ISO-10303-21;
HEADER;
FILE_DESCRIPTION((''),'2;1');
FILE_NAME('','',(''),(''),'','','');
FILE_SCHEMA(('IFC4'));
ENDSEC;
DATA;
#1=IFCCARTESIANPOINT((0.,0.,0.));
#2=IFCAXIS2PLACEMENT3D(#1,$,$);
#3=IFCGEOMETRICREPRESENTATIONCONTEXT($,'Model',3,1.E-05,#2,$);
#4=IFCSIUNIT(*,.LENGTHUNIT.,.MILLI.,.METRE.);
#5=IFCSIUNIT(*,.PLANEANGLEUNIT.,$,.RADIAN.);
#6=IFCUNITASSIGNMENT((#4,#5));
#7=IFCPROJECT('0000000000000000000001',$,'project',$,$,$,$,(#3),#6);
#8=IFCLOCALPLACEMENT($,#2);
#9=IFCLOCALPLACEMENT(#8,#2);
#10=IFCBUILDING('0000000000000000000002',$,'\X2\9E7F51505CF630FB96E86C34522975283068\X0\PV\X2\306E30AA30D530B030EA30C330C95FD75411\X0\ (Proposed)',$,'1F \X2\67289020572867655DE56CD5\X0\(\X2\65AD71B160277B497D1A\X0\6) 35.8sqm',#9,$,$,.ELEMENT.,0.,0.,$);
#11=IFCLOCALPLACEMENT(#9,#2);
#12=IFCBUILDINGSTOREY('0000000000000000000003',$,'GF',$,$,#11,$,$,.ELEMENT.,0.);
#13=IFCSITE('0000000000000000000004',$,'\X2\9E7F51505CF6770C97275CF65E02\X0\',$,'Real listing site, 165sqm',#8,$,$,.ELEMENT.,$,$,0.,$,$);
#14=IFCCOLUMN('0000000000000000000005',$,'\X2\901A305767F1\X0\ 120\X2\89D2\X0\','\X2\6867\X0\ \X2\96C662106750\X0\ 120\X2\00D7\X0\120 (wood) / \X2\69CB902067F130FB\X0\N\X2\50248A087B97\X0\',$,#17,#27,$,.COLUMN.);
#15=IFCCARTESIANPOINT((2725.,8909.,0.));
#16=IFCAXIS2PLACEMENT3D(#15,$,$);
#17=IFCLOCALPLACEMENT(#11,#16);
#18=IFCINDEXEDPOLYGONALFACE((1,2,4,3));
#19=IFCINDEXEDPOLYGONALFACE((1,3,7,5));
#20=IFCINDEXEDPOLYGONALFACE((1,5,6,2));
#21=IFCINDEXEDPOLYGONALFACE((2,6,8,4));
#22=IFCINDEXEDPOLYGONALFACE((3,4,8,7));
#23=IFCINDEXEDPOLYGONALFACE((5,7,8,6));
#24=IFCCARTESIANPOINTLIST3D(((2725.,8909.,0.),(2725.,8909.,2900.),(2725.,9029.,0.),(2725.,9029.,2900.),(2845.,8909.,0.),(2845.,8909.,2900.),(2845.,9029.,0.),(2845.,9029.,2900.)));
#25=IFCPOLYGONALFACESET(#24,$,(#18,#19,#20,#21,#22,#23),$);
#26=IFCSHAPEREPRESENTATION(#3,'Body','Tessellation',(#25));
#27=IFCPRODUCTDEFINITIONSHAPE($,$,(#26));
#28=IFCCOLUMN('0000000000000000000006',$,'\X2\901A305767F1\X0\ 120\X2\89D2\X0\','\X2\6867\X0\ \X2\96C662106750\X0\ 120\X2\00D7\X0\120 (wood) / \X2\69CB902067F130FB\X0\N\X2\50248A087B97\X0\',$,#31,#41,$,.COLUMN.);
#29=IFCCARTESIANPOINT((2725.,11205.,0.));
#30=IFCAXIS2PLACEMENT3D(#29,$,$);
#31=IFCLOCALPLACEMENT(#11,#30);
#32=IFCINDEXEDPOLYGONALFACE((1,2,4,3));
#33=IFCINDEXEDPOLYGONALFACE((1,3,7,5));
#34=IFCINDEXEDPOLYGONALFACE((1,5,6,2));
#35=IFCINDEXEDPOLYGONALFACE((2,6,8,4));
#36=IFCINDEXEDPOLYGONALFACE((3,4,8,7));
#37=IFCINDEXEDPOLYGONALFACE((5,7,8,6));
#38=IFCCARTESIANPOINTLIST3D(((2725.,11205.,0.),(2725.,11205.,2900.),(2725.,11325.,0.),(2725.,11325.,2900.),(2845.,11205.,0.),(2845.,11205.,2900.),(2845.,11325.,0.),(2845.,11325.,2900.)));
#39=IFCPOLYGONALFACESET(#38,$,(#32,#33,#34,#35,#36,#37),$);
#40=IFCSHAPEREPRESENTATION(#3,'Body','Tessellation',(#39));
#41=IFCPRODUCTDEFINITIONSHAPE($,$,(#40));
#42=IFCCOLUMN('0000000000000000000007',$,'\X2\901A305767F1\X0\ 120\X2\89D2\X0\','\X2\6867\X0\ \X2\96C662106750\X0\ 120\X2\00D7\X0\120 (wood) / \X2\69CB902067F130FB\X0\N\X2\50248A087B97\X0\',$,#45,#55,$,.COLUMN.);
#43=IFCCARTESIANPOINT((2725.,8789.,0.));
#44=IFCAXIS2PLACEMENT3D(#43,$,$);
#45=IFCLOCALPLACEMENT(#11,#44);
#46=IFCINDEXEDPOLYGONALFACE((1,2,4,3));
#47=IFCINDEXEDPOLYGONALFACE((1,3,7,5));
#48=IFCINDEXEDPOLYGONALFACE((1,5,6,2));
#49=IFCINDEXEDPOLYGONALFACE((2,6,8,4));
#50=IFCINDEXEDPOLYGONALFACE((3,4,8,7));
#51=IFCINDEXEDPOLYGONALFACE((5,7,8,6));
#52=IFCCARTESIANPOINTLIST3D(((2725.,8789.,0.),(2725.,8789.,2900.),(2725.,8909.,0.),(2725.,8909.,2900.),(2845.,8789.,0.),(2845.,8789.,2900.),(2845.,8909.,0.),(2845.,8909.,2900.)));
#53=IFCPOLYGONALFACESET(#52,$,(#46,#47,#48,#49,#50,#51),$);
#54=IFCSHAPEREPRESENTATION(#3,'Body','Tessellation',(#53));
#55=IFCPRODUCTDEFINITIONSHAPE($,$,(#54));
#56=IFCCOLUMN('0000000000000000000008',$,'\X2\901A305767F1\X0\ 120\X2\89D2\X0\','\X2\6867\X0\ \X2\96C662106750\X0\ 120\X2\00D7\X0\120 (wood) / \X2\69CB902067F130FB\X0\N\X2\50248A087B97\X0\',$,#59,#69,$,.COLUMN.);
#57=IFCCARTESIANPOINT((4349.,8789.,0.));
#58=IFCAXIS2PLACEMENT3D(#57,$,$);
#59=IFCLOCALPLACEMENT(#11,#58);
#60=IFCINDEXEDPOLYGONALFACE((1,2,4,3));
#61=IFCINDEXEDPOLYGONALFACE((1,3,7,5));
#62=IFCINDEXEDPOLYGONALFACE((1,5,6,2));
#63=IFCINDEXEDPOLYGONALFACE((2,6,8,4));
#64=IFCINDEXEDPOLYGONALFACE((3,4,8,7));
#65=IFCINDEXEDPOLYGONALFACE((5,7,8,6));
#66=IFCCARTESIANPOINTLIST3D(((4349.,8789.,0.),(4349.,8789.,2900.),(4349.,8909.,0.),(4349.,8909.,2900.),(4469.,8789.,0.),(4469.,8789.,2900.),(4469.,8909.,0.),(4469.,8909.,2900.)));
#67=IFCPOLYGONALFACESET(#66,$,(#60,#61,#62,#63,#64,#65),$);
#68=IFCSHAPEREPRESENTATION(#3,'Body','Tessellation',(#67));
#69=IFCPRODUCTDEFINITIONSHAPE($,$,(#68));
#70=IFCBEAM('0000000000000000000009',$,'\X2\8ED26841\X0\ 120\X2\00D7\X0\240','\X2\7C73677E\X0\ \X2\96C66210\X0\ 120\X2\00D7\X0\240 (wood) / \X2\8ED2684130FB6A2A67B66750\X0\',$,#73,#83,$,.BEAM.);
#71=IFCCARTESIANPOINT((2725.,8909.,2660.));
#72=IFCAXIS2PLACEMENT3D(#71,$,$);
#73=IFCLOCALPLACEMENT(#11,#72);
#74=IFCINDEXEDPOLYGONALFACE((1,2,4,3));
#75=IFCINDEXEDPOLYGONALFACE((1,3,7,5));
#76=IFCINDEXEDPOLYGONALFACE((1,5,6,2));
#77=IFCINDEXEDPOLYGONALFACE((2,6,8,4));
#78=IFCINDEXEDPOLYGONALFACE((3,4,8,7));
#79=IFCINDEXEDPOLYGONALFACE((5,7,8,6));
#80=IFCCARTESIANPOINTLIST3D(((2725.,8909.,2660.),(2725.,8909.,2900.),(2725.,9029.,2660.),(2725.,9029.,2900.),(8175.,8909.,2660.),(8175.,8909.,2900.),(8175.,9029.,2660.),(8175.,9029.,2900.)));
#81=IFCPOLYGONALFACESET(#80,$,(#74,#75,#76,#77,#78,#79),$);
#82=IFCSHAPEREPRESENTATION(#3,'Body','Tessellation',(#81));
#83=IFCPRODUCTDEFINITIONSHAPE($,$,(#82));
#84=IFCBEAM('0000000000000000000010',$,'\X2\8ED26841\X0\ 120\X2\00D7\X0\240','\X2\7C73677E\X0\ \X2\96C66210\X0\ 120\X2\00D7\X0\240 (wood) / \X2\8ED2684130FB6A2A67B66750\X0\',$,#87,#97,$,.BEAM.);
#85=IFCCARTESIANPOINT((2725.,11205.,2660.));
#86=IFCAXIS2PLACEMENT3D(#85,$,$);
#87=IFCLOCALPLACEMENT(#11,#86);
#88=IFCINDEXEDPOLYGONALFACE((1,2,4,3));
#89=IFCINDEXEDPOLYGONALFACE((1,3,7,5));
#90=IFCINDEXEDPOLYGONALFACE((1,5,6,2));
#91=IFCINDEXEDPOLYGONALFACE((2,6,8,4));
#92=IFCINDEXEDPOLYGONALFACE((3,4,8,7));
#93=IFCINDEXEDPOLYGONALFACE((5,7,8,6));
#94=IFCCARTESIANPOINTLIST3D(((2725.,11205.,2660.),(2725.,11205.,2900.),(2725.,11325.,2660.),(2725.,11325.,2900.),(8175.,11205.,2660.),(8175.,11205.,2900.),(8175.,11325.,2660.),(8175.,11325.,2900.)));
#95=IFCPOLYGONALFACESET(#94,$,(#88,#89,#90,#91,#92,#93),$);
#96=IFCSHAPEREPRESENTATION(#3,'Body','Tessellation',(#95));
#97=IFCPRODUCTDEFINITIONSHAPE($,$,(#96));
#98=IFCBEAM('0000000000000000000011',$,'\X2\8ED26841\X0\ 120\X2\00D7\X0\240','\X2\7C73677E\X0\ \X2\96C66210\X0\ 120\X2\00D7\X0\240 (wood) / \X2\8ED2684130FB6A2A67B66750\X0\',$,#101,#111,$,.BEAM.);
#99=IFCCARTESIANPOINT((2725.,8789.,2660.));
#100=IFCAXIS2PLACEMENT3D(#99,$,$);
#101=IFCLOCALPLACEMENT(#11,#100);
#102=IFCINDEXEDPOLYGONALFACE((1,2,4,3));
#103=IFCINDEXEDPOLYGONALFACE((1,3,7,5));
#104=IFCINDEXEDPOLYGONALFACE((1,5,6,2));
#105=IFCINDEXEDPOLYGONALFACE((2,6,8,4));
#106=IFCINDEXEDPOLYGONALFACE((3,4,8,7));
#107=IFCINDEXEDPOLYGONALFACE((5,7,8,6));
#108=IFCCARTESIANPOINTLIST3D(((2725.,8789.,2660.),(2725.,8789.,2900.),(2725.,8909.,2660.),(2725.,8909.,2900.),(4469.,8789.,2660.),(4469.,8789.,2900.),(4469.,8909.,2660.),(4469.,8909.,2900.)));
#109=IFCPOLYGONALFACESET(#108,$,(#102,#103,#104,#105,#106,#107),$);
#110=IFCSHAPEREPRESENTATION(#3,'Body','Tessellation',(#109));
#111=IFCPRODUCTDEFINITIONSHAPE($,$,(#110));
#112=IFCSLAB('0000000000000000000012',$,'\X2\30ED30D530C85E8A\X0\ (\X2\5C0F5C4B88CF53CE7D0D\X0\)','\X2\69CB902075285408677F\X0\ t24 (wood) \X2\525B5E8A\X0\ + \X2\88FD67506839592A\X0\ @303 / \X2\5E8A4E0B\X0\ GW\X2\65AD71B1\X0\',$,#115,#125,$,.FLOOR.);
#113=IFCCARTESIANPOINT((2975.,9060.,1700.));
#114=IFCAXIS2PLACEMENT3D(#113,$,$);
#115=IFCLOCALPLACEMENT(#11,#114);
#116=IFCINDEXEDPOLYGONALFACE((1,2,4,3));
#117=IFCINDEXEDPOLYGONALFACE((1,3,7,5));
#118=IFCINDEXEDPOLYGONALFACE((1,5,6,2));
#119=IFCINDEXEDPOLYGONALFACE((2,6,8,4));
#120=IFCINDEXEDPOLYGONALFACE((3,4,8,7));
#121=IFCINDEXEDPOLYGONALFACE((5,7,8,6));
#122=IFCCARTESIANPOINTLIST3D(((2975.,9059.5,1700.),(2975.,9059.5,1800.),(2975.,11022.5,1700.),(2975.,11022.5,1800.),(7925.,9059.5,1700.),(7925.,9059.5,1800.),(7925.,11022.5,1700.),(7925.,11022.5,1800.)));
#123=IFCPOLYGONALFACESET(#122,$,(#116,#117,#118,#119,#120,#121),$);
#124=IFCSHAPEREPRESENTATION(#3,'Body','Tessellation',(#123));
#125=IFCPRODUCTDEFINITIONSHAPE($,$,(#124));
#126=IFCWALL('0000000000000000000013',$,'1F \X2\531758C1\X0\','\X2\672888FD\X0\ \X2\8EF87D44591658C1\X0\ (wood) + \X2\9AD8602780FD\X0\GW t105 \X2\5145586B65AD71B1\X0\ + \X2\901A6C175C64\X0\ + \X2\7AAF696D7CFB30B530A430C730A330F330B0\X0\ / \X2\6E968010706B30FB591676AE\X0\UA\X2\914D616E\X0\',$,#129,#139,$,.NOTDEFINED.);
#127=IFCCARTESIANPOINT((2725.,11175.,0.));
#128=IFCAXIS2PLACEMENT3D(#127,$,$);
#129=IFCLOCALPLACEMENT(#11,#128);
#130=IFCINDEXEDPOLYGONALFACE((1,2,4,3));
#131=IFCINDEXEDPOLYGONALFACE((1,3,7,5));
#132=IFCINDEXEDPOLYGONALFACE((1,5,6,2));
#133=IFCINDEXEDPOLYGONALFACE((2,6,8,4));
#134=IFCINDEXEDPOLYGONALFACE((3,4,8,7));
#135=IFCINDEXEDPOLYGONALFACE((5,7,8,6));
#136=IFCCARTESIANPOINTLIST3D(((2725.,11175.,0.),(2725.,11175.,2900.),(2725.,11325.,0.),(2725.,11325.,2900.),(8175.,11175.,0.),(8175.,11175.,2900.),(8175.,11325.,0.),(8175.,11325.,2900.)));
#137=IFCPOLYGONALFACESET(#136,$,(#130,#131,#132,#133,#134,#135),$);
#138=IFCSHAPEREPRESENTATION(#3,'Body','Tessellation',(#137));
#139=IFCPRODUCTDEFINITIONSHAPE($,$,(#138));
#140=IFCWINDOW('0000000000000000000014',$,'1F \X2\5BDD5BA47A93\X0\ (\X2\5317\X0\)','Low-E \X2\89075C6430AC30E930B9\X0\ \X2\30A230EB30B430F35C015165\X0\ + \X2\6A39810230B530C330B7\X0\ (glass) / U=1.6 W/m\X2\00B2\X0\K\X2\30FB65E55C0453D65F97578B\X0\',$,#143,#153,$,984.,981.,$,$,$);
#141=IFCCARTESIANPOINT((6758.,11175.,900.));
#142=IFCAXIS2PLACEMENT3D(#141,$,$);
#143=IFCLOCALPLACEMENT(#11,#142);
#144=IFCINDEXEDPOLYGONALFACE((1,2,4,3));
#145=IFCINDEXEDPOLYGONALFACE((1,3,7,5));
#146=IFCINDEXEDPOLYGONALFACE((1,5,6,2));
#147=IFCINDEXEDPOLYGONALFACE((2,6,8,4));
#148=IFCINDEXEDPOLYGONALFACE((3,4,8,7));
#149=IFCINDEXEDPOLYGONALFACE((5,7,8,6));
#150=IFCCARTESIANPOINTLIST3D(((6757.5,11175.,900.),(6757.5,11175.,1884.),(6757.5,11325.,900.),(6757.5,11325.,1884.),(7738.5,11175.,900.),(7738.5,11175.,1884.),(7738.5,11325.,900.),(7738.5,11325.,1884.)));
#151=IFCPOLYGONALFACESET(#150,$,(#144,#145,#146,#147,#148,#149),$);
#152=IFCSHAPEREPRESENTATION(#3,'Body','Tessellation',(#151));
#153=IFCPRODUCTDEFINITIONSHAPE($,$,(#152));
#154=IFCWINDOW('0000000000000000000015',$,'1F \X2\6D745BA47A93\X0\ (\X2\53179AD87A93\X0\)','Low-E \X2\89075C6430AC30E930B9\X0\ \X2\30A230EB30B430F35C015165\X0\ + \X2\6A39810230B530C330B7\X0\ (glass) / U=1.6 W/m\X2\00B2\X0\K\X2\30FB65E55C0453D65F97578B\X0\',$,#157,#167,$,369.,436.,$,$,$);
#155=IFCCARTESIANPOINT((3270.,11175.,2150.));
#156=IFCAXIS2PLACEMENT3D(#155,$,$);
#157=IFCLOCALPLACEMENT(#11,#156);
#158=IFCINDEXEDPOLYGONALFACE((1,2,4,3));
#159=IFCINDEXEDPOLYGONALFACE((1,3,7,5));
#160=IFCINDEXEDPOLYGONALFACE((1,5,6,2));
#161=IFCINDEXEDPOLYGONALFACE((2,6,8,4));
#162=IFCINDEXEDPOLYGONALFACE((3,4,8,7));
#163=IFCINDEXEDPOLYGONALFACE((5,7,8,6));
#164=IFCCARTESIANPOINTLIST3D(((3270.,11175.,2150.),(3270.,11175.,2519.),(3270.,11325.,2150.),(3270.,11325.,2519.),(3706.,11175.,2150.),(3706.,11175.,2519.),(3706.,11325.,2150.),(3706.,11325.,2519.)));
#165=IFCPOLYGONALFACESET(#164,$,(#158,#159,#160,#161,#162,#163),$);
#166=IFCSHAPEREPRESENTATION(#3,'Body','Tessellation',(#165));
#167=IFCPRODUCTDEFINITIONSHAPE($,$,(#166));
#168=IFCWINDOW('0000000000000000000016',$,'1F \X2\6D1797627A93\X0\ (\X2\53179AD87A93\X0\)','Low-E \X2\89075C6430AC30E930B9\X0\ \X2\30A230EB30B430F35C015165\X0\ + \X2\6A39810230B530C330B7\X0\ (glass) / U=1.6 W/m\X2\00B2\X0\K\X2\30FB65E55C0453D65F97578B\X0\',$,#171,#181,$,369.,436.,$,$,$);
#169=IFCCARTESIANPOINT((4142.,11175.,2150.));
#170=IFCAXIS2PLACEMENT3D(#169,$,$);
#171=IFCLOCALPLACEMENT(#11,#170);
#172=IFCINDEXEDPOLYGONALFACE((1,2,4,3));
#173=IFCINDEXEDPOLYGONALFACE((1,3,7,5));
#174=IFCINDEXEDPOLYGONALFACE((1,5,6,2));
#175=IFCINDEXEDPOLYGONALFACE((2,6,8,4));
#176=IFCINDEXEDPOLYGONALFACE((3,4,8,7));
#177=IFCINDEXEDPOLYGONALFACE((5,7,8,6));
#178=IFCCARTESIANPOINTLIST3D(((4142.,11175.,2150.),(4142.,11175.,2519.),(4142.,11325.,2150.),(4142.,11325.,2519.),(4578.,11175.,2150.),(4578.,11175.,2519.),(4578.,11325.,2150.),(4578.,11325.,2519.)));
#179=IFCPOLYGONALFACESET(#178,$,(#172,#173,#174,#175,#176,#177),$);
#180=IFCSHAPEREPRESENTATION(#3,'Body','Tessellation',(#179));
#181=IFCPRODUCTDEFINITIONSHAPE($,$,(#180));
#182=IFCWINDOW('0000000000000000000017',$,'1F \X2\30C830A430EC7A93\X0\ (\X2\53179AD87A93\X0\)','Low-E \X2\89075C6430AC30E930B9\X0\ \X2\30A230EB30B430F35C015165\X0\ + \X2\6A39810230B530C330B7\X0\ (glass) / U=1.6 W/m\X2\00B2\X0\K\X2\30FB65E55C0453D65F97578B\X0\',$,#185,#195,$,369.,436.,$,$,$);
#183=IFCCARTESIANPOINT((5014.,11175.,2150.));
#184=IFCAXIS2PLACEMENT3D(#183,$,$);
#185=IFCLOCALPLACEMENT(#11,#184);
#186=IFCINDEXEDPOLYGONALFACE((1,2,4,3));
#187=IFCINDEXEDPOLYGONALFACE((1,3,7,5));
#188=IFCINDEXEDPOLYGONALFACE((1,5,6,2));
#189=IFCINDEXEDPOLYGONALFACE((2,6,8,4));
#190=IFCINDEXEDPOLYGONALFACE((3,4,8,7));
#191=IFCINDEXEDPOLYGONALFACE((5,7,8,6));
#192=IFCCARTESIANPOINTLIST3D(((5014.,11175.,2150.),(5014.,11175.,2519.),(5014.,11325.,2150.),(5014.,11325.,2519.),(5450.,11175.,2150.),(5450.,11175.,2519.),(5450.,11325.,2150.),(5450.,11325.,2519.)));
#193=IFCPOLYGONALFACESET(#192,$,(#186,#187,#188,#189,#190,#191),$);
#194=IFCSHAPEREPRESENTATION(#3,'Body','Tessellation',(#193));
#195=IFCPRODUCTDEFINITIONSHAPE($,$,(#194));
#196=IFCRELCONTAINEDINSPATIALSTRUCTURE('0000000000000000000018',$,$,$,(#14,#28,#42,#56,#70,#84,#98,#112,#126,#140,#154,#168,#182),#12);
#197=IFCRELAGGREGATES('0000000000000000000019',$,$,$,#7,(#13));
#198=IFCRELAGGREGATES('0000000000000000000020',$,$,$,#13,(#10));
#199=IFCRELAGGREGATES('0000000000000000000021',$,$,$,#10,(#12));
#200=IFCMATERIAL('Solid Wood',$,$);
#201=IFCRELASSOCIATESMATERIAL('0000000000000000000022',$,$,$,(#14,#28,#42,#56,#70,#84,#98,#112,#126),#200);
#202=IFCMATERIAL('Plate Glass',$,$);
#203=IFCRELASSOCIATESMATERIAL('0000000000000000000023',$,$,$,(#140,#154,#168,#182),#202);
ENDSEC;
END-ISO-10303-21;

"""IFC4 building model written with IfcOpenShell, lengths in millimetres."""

from ifc_helpers import new_model, si_unit, frame, frame_2d, origin, place, context, project, spatial, rectangle, extrude, material, element, fill, save


model = new_model("IFC4")

# Units and contexts
model_context = context("Model", 3, precision=1e-05, world=origin())
ifc_project = project(units=[si_unit("LENGTHUNIT", "METRE", prefix="MILLI"), si_unit("PLANEANGLEUNIT", "RADIAN")], contexts=[model_context])

# Site, building, storey
site_placement = place(None, origin())
site = spatial("IfcSite", under=ifc_project, at=site_placement, Name="鹿児島県霧島市", ObjectType="Real listing site, 165sqm", CompositionType="ELEMENT", RefElevation=0.0)
building_placement = place(site_placement, origin())
building = spatial("IfcBuilding", under=site, at=building_placement, Name="鹿児島・雨水利用とPVのオフグリッド志向 (Proposed)", ObjectType="1F 木造在来工法(断熱性等級6) 35.8sqm", CompositionType="ELEMENT", ElevationOfRefHeight=0.0, ElevationOfTerrain=0.0)
storey_placement = place(building_placement, origin())
storey = spatial("IfcBuildingStorey", under=building, at=storey_placement, Name="GF", CompositionType="ELEMENT", Elevation=0.0)

# Columns
ifc_material_1 = material(Name="Solid Wood")
column_1_placement = place(storey_placement, frame((2725.0, 8909.0, 0.0)))
element("IfcColumn", 1, at=column_1_placement, inside=storey, material=ifc_material_1, Name="通し柱 120角", Description="桧 集成材 120×120 (wood) / 構造柱・N値計算", PredefinedType="COLUMN", context=model_context, shape_type="SweptSolid", body=[
    extrude(rectangle(XDim=120.0, YDim=120.0, at=frame_2d((60.0, 60.0))), frame((2725.0, 8909.0, 0.0)), (0.0, 0.0, 1.0), 2900.0),
])
column_2_placement = place(storey_placement, frame((2725.0, 11205.0, 0.0)))
element("IfcColumn", 2, at=column_2_placement, inside=storey, material=ifc_material_1, Name="通し柱 120角", Description="桧 集成材 120×120 (wood) / 構造柱・N値計算", PredefinedType="COLUMN", context=model_context, shape_type="SweptSolid", body=[
    extrude(rectangle(XDim=120.0, YDim=120.0, at=frame_2d((60.0, 60.0))), frame((2725.0, 11205.0, 0.0)), (0.0, 0.0, 1.0), 2900.0),
])
column_3_placement = place(storey_placement, frame((2725.0, 8789.0, 0.0)))
element("IfcColumn", 3, at=column_3_placement, inside=storey, material=ifc_material_1, Name="通し柱 120角", Description="桧 集成材 120×120 (wood) / 構造柱・N値計算", PredefinedType="COLUMN", context=model_context, shape_type="SweptSolid", body=[
    extrude(rectangle(XDim=120.0, YDim=120.0, at=frame_2d((60.0, 60.0))), frame((2725.0, 8789.0, 0.0)), (0.0, 0.0, 1.0), 2900.0),
])
column_4_placement = place(storey_placement, frame((4349.0, 8789.0, 0.0)))
element("IfcColumn", 4, at=column_4_placement, inside=storey, material=ifc_material_1, Name="通し柱 120角", Description="桧 集成材 120×120 (wood) / 構造柱・N値計算", PredefinedType="COLUMN", context=model_context, shape_type="SweptSolid", body=[
    extrude(rectangle(XDim=120.0, YDim=120.0, at=frame_2d((60.0, 60.0))), frame((4349.0, 8789.0, 0.0)), (0.0, 0.0, 1.0), 2900.0),
])

# Beams
beam_1_placement = place(storey_placement, frame((2725.0, 8909.0, 2660.0)))
element("IfcBeam", 5, at=beam_1_placement, inside=storey, material=ifc_material_1, Name="軒桁 120×240", Description="米松 集成 120×240 (wood) / 軒桁・横架材", PredefinedType="BEAM", context=model_context, shape_type="SweptSolid", body=[
    extrude(rectangle(XDim=5450.0, YDim=120.0, at=frame_2d((2725.0, 60.0))), frame((2725.0, 8909.0, 2660.0)), (0.0, 0.0, 1.0), 240.0),
])
beam_2_placement = place(storey_placement, frame((2725.0, 11205.0, 2660.0)))
element("IfcBeam", 6, at=beam_2_placement, inside=storey, material=ifc_material_1, Name="軒桁 120×240", Description="米松 集成 120×240 (wood) / 軒桁・横架材", PredefinedType="BEAM", context=model_context, shape_type="SweptSolid", body=[
    extrude(rectangle(XDim=5450.0, YDim=120.0, at=frame_2d((2725.0, 60.0))), frame((2725.0, 11205.0, 2660.0)), (0.0, 0.0, 1.0), 240.0),
])
beam_3_placement = place(storey_placement, frame((2725.0, 8789.0, 2660.0)))
element("IfcBeam", 7, at=beam_3_placement, inside=storey, material=ifc_material_1, Name="軒桁 120×240", Description="米松 集成 120×240 (wood) / 軒桁・横架材", PredefinedType="BEAM", context=model_context, shape_type="SweptSolid", body=[
    extrude(rectangle(XDim=1744.0, YDim=120.0, at=frame_2d((872.0, 60.0))), frame((2725.0, 8789.0, 2660.0)), (0.0, 0.0, 1.0), 240.0),
])

# Slab
slab_1_placement = place(storey_placement, frame((2975.0, 9060.0, 1700.0)))
element("IfcSlab", 8, at=slab_1_placement, inside=storey, material=ifc_material_1, Name="ロフト床 (小屋裏収納)", Description="構造用合板 t24 (wood) 剛床 + 製材根太 @303 / 床下 GW断熱", PredefinedType="FLOOR", context=model_context, shape_type="SweptSolid", body=[
    extrude(rectangle(XDim=4950.0, YDim=1963.0, at=frame_2d((2475.0, 981.0))), frame((2975.0, 9060.0, 1700.0)), (0.0, 0.0, 1.0), 100.0),
])

# Wall, openings, windows
wall_1_placement = place(storey_placement, frame((2725.0, 11175.0, 0.0)))
wall_1 = element("IfcWall", 9, at=wall_1_placement, inside=storey, material=ifc_material_1, Name="1F 北壁", Description="木製 軸組外壁 (wood) + 高性能GW t105 充填断熱 + 通気層 + 窯業系サイディング / 準耐火・外皮UA配慮", PredefinedType="NOTDEFINED", context=model_context, shape_type="SweptSolid", body=[
    extrude(rectangle(XDim=5450.0, YDim=150.0, at=frame_2d((2725.0, 75.0))), frame((2725.0, 11175.0, 0.0)), (0.0, 0.0, 1.0), 2900.0),
])
opening_1_placement = place(storey_placement, frame((6758.0, 11175.0, 900.0)))
opening_1 = element("IfcOpeningElement", 10, at=opening_1_placement, cuts=wall_1, PredefinedType="NOTDEFINED", context=model_context, shape_type="SweptSolid", body=[
    extrude(rectangle(XDim=981.0, YDim=150.0, at=frame_2d((490.0, 75.0))), frame((6758.0, 11175.0, 900.0)), (0.0, 0.0, 1.0), 984.0),
])
opening_2_placement = place(storey_placement, frame((3270.0, 11175.0, 2150.0)))
opening_2 = element("IfcOpeningElement", 11, at=opening_2_placement, cuts=wall_1, PredefinedType="NOTDEFINED", context=model_context, shape_type="SweptSolid", body=[
    extrude(rectangle(XDim=436.0, YDim=150.0, at=frame_2d((218.0, 75.0))), frame((3270.0, 11175.0, 2150.0)), (0.0, 0.0, 1.0), 369.0),
])
opening_3_placement = place(storey_placement, frame((4142.0, 11175.0, 2150.0)))
opening_3 = element("IfcOpeningElement", 12, at=opening_3_placement, cuts=wall_1, PredefinedType="NOTDEFINED", context=model_context, shape_type="SweptSolid", body=[
    extrude(rectangle(XDim=436.0, YDim=150.0, at=frame_2d((218.0, 75.0))), frame((4142.0, 11175.0, 2150.0)), (0.0, 0.0, 1.0), 369.0),
])
opening_4_placement = place(storey_placement, frame((5014.0, 11175.0, 2150.0)))
opening_4 = element("IfcOpeningElement", 13, at=opening_4_placement, cuts=wall_1, PredefinedType="NOTDEFINED", context=model_context, shape_type="SweptSolid", body=[
    extrude(rectangle(XDim=436.0, YDim=150.0, at=frame_2d((218.0, 75.0))), frame((5014.0, 11175.0, 2150.0)), (0.0, 0.0, 1.0), 369.0),
])
ifc_material_2 = material(Name="Plate Glass")
window_1_placement = place(storey_placement, frame((6758.0, 11175.0, 900.0)))
window_1 = element("IfcWindow", 14, at=window_1_placement, inside=storey, material=ifc_material_2, Name="1F 寝室窓 (北)", Description="Low-E 複層ガラス アルゴン封入 + 樹脂サッシ (glass) / U=1.6 W/m²K・日射取得型", OverallHeight=984.0, OverallWidth=981.0, context=model_context, shape_type="SweptSolid", body=[
    extrude(rectangle(XDim=981.0, YDim=150.0, at=frame_2d((490.0, 75.0))), frame((6758.0, 11175.0, 900.0)), (0.0, 0.0, 1.0), 984.0),
])
fill(opening_1, window_1)
window_2_placement = place(storey_placement, frame((3270.0, 11175.0, 2150.0)))
window_2 = element("IfcWindow", 15, at=window_2_placement, inside=storey, material=ifc_material_2, Name="1F 浴室窓 (北高窓)", Description="Low-E 複層ガラス アルゴン封入 + 樹脂サッシ (glass) / U=1.6 W/m²K・日射取得型", OverallHeight=369.0, OverallWidth=436.0, context=model_context, shape_type="SweptSolid", body=[
    extrude(rectangle(XDim=436.0, YDim=150.0, at=frame_2d((218.0, 75.0))), frame((3270.0, 11175.0, 2150.0)), (0.0, 0.0, 1.0), 369.0),
])
fill(opening_2, window_2)
window_3_placement = place(storey_placement, frame((4142.0, 11175.0, 2150.0)))
window_3 = element("IfcWindow", 16, at=window_3_placement, inside=storey, material=ifc_material_2, Name="1F 洗面窓 (北高窓)", Description="Low-E 複層ガラス アルゴン封入 + 樹脂サッシ (glass) / U=1.6 W/m²K・日射取得型", OverallHeight=369.0, OverallWidth=436.0, context=model_context, shape_type="SweptSolid", body=[
    extrude(rectangle(XDim=436.0, YDim=150.0, at=frame_2d((218.0, 75.0))), frame((4142.0, 11175.0, 2150.0)), (0.0, 0.0, 1.0), 369.0),
])
fill(opening_3, window_3)
window_4_placement = place(storey_placement, frame((5014.0, 11175.0, 2150.0)))
window_4 = element("IfcWindow", 17, at=window_4_placement, inside=storey, material=ifc_material_2, Name="1F トイレ窓 (北高窓)", Description="Low-E 複層ガラス アルゴン封入 + 樹脂サッシ (glass) / U=1.6 W/m²K・日射取得型", OverallHeight=369.0, OverallWidth=436.0, context=model_context, shape_type="SweptSolid", body=[
    extrude(rectangle(XDim=436.0, YDim=150.0, at=frame_2d((218.0, 75.0))), frame((5014.0, 11175.0, 2150.0)), (0.0, 0.0, 1.0), 369.0),
])
fill(opening_4, window_4)

save(model, "model.ifc")
